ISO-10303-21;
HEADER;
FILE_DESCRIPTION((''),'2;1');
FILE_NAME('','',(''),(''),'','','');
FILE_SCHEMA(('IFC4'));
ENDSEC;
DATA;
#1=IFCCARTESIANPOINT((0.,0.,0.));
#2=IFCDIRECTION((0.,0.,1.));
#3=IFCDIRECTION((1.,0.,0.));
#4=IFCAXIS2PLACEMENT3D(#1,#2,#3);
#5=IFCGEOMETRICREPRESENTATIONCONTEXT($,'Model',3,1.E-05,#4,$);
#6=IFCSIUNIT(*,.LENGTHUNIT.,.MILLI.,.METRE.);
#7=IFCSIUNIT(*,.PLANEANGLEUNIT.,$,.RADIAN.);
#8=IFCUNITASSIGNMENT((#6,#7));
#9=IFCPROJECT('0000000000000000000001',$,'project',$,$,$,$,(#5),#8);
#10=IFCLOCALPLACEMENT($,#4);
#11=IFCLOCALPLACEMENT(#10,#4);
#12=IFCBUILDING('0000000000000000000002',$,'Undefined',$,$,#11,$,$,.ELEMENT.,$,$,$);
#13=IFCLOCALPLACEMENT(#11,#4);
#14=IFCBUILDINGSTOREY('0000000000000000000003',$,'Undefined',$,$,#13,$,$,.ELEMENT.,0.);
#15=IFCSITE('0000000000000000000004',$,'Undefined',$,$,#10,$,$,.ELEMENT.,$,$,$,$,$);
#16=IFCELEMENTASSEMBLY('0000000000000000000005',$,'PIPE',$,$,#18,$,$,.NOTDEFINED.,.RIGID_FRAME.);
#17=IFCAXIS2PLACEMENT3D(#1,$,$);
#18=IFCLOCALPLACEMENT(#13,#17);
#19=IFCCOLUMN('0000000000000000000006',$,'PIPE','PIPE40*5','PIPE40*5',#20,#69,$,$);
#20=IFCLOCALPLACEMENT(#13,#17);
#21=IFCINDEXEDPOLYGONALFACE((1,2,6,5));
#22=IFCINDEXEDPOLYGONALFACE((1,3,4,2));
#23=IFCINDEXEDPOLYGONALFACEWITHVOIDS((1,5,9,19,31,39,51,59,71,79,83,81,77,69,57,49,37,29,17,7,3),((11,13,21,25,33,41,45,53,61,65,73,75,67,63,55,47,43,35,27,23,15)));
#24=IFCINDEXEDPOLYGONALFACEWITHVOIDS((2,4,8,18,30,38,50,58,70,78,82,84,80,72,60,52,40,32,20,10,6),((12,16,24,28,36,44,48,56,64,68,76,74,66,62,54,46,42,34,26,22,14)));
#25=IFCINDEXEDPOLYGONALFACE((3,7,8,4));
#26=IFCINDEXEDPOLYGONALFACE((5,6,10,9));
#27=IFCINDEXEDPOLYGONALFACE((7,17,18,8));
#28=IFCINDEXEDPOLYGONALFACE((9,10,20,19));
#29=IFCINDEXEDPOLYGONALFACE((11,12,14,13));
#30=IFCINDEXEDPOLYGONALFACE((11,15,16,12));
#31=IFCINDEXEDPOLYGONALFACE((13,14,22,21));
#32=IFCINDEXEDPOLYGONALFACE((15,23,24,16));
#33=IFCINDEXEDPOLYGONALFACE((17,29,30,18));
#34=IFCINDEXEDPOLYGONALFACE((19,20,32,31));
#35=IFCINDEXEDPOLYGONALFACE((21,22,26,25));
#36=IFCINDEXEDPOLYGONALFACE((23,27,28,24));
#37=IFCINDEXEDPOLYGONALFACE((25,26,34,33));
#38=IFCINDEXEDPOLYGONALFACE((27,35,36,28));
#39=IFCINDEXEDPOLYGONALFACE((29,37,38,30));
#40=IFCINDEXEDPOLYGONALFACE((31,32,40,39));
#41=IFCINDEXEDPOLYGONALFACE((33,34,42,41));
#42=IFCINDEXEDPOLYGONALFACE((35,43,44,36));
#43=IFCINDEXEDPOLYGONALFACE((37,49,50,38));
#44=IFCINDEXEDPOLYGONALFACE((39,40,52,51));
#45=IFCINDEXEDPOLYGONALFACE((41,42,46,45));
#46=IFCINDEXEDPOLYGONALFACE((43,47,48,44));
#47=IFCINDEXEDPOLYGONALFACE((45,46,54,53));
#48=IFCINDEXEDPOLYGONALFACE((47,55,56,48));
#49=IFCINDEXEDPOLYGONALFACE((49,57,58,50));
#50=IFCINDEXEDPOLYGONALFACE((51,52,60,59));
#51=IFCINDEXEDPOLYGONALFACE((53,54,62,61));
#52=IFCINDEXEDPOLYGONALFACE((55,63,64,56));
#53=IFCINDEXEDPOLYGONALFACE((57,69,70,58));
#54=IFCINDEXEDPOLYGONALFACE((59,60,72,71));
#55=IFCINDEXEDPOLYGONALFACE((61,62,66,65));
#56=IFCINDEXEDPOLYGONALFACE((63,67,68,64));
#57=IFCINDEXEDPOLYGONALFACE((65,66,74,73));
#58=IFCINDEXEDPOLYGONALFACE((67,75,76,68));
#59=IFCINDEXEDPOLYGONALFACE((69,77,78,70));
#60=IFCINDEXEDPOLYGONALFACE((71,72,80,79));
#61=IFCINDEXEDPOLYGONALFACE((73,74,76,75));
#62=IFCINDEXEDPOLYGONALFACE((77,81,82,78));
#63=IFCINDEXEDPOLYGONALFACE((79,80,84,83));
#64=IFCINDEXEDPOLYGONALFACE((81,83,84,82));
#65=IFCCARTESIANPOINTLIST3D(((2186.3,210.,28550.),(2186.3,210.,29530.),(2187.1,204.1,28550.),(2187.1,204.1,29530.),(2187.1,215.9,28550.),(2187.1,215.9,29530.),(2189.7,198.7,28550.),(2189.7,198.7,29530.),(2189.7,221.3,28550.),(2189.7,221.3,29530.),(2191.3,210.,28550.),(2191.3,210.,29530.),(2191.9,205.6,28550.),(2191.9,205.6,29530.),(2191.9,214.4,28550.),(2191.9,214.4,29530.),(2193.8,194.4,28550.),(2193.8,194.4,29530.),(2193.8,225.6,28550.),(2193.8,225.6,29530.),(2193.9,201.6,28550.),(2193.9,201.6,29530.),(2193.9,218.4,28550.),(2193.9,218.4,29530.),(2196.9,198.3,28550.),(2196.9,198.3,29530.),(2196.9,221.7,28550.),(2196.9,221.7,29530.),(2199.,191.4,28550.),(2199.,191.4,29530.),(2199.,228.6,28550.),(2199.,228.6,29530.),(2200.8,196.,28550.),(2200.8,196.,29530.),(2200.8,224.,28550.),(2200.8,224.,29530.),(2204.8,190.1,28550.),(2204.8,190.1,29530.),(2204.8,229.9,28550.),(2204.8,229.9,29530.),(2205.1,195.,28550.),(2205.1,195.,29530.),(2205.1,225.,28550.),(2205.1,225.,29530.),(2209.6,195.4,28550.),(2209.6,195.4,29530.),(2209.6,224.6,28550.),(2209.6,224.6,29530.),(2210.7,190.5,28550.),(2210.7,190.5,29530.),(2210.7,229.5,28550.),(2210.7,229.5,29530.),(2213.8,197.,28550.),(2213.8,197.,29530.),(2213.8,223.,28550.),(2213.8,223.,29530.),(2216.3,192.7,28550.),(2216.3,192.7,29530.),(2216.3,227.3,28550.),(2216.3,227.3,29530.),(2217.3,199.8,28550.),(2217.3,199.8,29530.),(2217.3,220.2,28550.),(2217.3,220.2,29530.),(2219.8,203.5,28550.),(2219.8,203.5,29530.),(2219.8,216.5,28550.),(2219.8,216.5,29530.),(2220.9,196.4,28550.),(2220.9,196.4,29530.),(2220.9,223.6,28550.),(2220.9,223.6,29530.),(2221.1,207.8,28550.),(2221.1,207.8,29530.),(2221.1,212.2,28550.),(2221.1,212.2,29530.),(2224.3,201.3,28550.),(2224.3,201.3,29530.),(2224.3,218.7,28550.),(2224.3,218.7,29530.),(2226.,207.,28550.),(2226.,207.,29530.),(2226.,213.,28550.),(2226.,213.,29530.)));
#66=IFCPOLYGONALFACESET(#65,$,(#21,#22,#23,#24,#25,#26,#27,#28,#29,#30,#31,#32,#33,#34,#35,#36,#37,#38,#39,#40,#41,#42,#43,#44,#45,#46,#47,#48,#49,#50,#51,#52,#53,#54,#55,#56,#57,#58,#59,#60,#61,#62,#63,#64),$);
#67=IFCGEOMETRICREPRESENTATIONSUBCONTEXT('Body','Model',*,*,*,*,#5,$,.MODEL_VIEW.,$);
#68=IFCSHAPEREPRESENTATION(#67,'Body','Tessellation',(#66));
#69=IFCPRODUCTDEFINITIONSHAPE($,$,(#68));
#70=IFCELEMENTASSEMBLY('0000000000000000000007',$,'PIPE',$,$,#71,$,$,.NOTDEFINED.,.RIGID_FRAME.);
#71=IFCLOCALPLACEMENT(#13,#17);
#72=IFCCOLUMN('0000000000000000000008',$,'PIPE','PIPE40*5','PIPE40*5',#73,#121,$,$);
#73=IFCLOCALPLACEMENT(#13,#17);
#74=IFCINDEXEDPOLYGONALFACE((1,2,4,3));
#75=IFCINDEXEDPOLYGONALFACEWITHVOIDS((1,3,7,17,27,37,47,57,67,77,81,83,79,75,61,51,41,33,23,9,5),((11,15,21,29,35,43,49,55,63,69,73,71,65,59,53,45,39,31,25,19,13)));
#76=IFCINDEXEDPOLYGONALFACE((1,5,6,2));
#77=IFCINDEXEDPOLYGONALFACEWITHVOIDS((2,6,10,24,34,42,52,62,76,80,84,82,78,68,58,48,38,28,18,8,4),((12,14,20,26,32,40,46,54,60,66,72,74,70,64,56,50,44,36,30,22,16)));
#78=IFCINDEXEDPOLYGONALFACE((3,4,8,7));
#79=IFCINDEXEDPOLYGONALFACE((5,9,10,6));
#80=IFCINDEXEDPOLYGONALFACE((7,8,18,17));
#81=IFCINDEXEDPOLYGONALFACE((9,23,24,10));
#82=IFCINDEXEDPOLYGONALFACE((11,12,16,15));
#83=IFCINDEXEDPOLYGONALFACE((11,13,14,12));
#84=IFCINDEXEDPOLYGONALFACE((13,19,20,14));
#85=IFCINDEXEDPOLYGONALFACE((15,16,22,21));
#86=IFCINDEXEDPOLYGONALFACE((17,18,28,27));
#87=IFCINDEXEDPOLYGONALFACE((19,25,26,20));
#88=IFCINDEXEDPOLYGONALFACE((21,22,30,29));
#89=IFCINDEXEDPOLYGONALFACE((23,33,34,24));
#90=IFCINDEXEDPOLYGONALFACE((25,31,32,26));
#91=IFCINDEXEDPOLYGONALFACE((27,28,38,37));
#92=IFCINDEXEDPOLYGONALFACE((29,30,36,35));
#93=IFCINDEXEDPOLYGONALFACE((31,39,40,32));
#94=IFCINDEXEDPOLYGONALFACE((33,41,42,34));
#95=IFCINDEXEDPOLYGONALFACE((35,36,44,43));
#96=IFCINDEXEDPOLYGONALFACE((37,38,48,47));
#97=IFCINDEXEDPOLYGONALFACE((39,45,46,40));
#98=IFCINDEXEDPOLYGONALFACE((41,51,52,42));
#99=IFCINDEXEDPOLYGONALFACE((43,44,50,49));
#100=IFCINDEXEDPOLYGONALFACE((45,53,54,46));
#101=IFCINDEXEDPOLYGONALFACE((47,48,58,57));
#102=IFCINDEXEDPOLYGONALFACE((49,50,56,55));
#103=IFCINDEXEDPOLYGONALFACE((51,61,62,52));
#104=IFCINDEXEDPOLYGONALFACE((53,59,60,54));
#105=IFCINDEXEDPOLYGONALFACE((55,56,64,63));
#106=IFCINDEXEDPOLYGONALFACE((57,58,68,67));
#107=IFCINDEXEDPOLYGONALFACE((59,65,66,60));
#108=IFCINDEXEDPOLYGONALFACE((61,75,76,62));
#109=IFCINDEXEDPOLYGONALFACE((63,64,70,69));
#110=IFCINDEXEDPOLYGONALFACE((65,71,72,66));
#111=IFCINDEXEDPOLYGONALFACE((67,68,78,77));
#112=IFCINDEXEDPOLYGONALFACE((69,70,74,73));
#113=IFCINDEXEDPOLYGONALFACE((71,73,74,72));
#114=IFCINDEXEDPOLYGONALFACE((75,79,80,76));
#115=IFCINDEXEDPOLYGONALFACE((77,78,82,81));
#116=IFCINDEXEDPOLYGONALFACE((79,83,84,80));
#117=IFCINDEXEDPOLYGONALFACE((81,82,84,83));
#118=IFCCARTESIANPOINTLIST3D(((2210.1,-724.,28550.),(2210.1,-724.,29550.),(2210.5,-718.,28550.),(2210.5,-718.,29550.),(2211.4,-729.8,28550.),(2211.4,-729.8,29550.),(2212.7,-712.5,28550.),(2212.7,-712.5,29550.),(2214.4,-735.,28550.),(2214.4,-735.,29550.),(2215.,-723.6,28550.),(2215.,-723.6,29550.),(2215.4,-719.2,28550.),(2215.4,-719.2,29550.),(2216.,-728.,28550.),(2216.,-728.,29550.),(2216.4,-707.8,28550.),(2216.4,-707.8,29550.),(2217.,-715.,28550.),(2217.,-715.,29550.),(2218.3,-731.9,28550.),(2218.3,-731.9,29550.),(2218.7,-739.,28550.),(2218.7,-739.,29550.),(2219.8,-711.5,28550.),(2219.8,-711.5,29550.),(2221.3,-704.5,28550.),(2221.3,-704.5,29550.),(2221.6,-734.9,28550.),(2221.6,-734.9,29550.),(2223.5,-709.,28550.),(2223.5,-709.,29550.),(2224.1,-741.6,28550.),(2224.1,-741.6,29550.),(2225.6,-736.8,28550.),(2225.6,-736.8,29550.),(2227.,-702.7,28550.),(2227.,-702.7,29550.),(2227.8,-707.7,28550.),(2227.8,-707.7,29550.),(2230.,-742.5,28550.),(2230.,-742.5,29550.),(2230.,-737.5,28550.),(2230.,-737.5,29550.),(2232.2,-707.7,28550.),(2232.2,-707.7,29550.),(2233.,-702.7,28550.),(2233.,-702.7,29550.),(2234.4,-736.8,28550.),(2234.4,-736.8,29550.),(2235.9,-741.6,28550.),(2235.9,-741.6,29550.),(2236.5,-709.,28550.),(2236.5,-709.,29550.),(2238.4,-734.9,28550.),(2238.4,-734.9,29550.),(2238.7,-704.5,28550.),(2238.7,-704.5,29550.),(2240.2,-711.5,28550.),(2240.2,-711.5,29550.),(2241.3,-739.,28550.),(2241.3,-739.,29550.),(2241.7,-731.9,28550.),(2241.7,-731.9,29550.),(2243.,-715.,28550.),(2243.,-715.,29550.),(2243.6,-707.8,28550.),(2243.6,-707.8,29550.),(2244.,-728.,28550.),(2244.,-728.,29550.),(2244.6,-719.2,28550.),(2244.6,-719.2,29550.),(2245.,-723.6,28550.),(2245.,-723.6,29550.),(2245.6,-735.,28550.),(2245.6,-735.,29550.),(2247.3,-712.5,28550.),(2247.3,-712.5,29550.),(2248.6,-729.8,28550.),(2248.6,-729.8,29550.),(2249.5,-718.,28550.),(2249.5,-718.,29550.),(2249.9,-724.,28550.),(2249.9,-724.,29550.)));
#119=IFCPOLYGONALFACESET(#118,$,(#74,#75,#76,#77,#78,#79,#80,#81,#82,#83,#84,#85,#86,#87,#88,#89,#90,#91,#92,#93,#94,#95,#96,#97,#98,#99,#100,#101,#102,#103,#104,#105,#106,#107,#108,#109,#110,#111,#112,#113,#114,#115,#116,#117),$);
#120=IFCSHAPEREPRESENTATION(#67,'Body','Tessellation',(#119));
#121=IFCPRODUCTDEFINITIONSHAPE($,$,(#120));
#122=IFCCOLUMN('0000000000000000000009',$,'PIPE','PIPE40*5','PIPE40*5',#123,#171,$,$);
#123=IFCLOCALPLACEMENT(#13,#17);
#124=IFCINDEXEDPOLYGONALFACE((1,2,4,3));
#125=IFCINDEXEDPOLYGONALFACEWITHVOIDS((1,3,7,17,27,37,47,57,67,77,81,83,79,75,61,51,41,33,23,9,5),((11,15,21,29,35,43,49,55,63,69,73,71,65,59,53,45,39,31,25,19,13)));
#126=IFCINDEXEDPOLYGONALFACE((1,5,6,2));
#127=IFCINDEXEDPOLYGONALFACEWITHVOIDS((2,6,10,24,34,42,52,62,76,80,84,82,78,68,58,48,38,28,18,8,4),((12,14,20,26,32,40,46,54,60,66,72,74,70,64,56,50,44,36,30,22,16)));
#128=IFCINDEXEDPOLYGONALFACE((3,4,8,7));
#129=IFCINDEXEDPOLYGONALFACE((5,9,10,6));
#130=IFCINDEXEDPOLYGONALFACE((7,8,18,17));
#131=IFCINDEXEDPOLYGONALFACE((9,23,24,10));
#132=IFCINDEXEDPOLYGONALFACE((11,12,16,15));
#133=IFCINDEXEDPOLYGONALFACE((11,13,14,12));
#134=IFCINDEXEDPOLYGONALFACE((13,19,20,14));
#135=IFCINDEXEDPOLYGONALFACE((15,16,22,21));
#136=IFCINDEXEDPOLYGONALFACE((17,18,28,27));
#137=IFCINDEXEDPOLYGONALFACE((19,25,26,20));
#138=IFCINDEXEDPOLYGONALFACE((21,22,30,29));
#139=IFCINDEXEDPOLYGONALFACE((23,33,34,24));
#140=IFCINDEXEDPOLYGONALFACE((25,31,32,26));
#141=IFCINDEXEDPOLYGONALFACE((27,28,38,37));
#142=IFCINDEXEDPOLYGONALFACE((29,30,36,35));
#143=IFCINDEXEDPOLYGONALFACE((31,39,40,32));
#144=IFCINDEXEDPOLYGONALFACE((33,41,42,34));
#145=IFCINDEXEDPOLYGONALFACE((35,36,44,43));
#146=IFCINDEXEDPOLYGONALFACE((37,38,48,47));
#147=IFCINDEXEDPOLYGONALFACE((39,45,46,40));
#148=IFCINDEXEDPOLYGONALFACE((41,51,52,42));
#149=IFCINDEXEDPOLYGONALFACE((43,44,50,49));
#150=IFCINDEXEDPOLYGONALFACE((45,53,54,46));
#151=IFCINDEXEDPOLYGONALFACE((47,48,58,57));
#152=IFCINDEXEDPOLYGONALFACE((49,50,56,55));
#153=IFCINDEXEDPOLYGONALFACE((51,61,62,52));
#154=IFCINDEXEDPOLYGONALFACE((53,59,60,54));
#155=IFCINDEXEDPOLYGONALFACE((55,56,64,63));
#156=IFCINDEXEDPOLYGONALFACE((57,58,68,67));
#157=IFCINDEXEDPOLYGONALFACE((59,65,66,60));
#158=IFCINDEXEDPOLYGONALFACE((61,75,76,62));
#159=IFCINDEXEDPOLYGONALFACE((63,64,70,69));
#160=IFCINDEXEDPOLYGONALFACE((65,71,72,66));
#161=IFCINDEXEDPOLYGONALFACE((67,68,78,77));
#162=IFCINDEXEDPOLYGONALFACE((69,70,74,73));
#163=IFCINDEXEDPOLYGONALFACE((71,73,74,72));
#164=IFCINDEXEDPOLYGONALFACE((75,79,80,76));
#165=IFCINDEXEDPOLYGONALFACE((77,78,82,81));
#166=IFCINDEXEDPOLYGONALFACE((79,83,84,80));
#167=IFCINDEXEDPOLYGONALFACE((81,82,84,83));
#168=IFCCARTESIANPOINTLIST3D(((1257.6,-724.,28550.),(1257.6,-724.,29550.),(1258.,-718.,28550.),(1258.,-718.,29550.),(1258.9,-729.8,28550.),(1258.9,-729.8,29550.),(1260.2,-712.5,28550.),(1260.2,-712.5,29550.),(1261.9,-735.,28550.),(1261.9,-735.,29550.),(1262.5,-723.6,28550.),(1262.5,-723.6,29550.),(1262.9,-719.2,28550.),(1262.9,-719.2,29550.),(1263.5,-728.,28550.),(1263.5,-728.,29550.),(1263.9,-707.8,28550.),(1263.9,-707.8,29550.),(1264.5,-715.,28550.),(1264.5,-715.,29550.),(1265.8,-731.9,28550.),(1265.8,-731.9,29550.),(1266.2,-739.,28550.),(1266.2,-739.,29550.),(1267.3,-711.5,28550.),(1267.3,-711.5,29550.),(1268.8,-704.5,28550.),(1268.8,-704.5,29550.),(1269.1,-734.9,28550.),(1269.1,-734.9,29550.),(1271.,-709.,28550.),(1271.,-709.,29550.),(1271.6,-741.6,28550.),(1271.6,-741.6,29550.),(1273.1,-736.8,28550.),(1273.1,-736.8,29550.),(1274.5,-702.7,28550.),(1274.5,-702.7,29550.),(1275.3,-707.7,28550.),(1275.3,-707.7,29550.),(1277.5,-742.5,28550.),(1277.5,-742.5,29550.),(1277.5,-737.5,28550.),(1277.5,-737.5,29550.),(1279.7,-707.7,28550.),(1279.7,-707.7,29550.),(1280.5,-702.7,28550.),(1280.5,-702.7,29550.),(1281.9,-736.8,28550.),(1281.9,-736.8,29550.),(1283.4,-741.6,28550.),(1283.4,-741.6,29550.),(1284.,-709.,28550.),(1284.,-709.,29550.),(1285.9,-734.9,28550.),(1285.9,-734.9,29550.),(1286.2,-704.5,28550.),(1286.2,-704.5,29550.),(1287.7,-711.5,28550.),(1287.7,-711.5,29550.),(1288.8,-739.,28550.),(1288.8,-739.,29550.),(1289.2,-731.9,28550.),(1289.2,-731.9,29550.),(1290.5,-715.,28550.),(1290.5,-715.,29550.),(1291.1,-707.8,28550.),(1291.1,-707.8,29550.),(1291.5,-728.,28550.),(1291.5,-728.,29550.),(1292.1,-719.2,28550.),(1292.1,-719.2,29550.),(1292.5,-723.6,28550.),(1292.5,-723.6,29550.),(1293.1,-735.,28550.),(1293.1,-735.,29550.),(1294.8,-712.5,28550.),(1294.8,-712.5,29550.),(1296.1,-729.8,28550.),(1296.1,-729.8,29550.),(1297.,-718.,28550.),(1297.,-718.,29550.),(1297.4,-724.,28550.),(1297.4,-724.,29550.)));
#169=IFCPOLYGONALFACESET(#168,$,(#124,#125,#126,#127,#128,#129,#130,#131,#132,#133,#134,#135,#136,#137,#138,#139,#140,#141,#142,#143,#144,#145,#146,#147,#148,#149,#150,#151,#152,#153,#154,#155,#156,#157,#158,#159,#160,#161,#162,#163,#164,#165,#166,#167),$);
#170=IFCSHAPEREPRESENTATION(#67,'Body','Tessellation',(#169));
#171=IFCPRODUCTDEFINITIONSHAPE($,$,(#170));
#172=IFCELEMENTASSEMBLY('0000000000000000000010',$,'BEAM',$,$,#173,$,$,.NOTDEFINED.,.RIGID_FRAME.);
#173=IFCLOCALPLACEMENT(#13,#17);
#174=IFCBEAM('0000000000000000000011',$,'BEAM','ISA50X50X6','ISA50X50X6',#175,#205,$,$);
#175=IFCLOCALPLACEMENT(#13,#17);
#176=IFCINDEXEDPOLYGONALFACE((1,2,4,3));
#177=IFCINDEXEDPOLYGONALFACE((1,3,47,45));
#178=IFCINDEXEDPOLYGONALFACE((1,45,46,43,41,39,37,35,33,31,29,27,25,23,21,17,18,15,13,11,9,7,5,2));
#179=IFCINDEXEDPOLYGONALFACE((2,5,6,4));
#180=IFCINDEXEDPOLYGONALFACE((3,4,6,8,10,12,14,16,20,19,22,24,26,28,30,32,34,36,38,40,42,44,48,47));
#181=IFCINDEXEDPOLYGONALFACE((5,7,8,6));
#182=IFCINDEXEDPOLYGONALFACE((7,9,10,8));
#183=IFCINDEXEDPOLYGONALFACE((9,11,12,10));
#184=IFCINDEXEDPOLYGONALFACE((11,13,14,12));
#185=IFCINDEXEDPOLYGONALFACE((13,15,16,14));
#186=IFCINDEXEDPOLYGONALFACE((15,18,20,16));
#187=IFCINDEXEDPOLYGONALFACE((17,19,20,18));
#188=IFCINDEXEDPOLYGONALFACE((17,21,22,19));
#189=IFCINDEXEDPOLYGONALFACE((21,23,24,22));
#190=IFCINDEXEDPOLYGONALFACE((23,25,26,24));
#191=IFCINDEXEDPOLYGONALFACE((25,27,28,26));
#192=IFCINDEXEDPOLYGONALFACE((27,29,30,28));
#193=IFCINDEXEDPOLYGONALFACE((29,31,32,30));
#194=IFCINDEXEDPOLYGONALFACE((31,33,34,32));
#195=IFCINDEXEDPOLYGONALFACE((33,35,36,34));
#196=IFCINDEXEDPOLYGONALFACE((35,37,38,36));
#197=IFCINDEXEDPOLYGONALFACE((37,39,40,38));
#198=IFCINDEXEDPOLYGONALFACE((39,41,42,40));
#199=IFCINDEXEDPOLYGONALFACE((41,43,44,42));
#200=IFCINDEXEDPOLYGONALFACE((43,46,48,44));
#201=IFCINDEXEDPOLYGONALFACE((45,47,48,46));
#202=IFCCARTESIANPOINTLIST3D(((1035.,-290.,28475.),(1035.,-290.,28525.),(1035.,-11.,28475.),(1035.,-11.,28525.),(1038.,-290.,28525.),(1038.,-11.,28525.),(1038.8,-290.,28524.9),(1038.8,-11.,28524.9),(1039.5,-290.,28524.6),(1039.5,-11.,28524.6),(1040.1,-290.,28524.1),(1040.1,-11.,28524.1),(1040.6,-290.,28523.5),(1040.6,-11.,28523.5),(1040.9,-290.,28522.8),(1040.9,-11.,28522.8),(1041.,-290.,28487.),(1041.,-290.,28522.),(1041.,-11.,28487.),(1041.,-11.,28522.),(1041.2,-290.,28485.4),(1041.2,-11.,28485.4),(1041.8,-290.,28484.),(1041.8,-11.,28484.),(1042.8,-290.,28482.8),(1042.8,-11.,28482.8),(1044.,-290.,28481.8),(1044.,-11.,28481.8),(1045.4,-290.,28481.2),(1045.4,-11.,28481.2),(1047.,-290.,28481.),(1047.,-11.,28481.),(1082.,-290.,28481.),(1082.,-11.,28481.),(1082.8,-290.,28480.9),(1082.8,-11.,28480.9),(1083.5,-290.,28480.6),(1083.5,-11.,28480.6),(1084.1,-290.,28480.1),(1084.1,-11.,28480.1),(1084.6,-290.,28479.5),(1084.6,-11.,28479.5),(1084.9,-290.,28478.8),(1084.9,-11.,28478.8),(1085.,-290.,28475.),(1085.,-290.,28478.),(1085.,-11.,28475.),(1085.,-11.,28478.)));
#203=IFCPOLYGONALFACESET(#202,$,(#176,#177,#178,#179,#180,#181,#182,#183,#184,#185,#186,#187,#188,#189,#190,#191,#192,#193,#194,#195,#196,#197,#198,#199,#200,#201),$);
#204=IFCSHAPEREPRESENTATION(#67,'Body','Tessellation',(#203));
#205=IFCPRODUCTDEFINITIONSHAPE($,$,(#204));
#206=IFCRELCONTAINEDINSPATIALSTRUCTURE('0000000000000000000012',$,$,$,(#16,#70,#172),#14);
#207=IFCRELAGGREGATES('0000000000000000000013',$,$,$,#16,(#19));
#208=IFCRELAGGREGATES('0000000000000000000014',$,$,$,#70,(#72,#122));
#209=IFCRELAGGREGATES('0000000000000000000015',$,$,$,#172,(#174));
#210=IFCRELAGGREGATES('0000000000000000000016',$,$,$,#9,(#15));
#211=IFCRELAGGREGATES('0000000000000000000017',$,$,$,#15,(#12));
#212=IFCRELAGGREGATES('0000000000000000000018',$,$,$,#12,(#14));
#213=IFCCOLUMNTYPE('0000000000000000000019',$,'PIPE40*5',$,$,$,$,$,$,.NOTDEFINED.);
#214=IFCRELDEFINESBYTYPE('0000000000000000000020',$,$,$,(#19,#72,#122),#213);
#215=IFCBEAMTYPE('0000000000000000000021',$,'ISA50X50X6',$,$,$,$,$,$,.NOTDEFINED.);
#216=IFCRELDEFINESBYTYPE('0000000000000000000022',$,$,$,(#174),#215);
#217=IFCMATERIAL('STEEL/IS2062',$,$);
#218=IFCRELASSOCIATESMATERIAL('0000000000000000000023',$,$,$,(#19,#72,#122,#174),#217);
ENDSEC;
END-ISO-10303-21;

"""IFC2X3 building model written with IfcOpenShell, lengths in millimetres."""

from ifc_helpers import new_model, si_unit, frame, origin_with_axes, origin_2d_with_axis, place, context, subcontext, project, spatial, hollow_circle, l_section, extrude, clip, halfspace, material, type_object, element, aggregate, save


model = new_model("IFC2X3")

# Units and contexts
model_context = context("Model", 3, precision=1e-05, world=origin_with_axes())
body_context = subcontext(model_context, "Body", "Model", "MODEL_VIEW")
ifc_project = project(units=[si_unit("LENGTHUNIT", "METRE", prefix="MILLI"), si_unit("PLANEANGLEUNIT", "RADIAN")], contexts=[model_context])

# Site, building, storey
site_placement = place(None, origin_with_axes())
site = spatial("IfcSite", under=ifc_project, at=site_placement, Name="Undefined", CompositionType="ELEMENT")
building_placement = place(site_placement, origin_with_axes())
building = spatial("IfcBuilding", under=site, at=building_placement, Name="Undefined", CompositionType="ELEMENT")
storey_placement = place(building_placement, origin_with_axes())
storey = spatial("IfcBuildingStorey", under=building, at=storey_placement, Name="Undefined", CompositionType="ELEMENT", Elevation=0.0)

# Element assembly, column
assembly_1_placement = place(storey_placement, origin_with_axes())
assembly_1 = element("IfcElementAssembly", 1, at=assembly_1_placement, inside=storey, Name="PIPE", AssemblyPlace="NOTDEFINED", PredefinedType="RIGID_FRAME")
ifc_material_1 = material(Name="STEEL/IS2062")
column_type = type_object("IfcColumnType", Name="PIPE40*5", PredefinedType="NOTDEFINED")
column_1_placement = place(assembly_1_placement, frame((2206.3, 210.0, 28550.0), z_axis=(0.0, 0.0, 1.0), x_axis=(0.0, 1.0, 0.0)))
column_1 = element("IfcColumn", 2, at=column_1_placement, type_object=column_type, material=ifc_material_1, Name="PIPE", Description="PIPE40*5", ObjectType="PIPE40*5", context=body_context, shape_type="Clipping", body=[
    clip(extrude(hollow_circle(Radius=20.0, WallThickness=5.0, at=origin_2d_with_axis()), frame((0.0, 0.0, 1000.0), z_axis=(0.0, 0.0, -1.0), x_axis=(0.0, 1.0, 0.0)), (0.0, 0.0, 1.0), 1000.0), halfspace(frame((0.0, 0.0, 980.0), z_axis=(0.0, 0.0, 1.0), x_axis=(1.0, 0.0, 0.0)), False)),
])
aggregate(assembly_1, [column_1])

# Element assembly, columns
assembly_2_placement = place(storey_placement, origin_with_axes())
assembly_2 = element("IfcElementAssembly", 3, at=assembly_2_placement, inside=storey, Name="PIPE", AssemblyPlace="NOTDEFINED", PredefinedType="RIGID_FRAME")
column_2_placement = place(assembly_2_placement, frame((2230.0, -722.5, 28550.0), z_axis=(0.0, 0.0, 1.0), x_axis=(-1.0, 0.0, 0.0)))
column_2 = element("IfcColumn", 4, at=column_2_placement, type_object=column_type, material=ifc_material_1, Name="PIPE", Description="PIPE40*5", ObjectType="PIPE40*5", context=body_context, shape_type="SweptSolid", body=[
    extrude(hollow_circle(Radius=20.0, WallThickness=5.0, at=origin_2d_with_axis()), frame((0.0, 0.0, 1000.0), z_axis=(0.0, 0.0, -1.0), x_axis=(0.0, 1.0, 0.0)), (0.0, 0.0, 1.0), 1000.0),
])
column_3_placement = place(assembly_2_placement, frame((1277.5, -722.5, 28550.0), z_axis=(0.0, 0.0, 1.0), x_axis=(-1.0, 0.0, 0.0)))
column_3 = element("IfcColumn", 5, at=column_3_placement, type_object=column_type, material=ifc_material_1, Name="PIPE", Description="PIPE40*5", ObjectType="PIPE40*5", context=body_context, shape_type="SweptSolid", body=[
    extrude(hollow_circle(Radius=20.0, WallThickness=5.0, at=origin_2d_with_axis()), frame((0.0, 0.0, 1000.0), z_axis=(0.0, 0.0, -1.0), x_axis=(0.0, 1.0, 0.0)), (0.0, 0.0, 1.0), 1000.0),
])
aggregate(assembly_2, [column_2, column_3])

# Element assembly, beam
assembly_3_placement = place(storey_placement, origin_with_axes())
assembly_3 = element("IfcElementAssembly", 6, at=assembly_3_placement, inside=storey, Name="BEAM", AssemblyPlace="NOTDEFINED", PredefinedType="RIGID_FRAME")
beam_type_1 = type_object("IfcBeamType", Name="ISA50X50X6", PredefinedType="NOTDEFINED")
beam_1_placement = place(assembly_3_placement, frame((1060.0, -290.0, 28500.0), z_axis=(0.0, 0.0, 1.0), x_axis=(0.0, 1.0, 0.0)))
beam_1 = element("IfcBeam", 7, at=beam_1_placement, type_object=beam_type_1, material=ifc_material_1, Name="BEAM", Description="ISA50X50X6", ObjectType="ISA50X50X6", context=body_context, shape_type="SweptSolid", body=[
    extrude(l_section(Depth=50.0, Width=50.0, Thickness=6.0, FilletRadius=6.0, EdgeRadius=3.0, at=origin_2d_with_axis()), frame((279.0, 0.0, 0.0), z_axis=(-1.0, 0.0, 0.0), x_axis=(0.0, -1.0, 0.0)), (0.0, 0.0, 1.0), 279.0),
])
aggregate(assembly_3, [beam_1])

save(model, "model.ifc")
